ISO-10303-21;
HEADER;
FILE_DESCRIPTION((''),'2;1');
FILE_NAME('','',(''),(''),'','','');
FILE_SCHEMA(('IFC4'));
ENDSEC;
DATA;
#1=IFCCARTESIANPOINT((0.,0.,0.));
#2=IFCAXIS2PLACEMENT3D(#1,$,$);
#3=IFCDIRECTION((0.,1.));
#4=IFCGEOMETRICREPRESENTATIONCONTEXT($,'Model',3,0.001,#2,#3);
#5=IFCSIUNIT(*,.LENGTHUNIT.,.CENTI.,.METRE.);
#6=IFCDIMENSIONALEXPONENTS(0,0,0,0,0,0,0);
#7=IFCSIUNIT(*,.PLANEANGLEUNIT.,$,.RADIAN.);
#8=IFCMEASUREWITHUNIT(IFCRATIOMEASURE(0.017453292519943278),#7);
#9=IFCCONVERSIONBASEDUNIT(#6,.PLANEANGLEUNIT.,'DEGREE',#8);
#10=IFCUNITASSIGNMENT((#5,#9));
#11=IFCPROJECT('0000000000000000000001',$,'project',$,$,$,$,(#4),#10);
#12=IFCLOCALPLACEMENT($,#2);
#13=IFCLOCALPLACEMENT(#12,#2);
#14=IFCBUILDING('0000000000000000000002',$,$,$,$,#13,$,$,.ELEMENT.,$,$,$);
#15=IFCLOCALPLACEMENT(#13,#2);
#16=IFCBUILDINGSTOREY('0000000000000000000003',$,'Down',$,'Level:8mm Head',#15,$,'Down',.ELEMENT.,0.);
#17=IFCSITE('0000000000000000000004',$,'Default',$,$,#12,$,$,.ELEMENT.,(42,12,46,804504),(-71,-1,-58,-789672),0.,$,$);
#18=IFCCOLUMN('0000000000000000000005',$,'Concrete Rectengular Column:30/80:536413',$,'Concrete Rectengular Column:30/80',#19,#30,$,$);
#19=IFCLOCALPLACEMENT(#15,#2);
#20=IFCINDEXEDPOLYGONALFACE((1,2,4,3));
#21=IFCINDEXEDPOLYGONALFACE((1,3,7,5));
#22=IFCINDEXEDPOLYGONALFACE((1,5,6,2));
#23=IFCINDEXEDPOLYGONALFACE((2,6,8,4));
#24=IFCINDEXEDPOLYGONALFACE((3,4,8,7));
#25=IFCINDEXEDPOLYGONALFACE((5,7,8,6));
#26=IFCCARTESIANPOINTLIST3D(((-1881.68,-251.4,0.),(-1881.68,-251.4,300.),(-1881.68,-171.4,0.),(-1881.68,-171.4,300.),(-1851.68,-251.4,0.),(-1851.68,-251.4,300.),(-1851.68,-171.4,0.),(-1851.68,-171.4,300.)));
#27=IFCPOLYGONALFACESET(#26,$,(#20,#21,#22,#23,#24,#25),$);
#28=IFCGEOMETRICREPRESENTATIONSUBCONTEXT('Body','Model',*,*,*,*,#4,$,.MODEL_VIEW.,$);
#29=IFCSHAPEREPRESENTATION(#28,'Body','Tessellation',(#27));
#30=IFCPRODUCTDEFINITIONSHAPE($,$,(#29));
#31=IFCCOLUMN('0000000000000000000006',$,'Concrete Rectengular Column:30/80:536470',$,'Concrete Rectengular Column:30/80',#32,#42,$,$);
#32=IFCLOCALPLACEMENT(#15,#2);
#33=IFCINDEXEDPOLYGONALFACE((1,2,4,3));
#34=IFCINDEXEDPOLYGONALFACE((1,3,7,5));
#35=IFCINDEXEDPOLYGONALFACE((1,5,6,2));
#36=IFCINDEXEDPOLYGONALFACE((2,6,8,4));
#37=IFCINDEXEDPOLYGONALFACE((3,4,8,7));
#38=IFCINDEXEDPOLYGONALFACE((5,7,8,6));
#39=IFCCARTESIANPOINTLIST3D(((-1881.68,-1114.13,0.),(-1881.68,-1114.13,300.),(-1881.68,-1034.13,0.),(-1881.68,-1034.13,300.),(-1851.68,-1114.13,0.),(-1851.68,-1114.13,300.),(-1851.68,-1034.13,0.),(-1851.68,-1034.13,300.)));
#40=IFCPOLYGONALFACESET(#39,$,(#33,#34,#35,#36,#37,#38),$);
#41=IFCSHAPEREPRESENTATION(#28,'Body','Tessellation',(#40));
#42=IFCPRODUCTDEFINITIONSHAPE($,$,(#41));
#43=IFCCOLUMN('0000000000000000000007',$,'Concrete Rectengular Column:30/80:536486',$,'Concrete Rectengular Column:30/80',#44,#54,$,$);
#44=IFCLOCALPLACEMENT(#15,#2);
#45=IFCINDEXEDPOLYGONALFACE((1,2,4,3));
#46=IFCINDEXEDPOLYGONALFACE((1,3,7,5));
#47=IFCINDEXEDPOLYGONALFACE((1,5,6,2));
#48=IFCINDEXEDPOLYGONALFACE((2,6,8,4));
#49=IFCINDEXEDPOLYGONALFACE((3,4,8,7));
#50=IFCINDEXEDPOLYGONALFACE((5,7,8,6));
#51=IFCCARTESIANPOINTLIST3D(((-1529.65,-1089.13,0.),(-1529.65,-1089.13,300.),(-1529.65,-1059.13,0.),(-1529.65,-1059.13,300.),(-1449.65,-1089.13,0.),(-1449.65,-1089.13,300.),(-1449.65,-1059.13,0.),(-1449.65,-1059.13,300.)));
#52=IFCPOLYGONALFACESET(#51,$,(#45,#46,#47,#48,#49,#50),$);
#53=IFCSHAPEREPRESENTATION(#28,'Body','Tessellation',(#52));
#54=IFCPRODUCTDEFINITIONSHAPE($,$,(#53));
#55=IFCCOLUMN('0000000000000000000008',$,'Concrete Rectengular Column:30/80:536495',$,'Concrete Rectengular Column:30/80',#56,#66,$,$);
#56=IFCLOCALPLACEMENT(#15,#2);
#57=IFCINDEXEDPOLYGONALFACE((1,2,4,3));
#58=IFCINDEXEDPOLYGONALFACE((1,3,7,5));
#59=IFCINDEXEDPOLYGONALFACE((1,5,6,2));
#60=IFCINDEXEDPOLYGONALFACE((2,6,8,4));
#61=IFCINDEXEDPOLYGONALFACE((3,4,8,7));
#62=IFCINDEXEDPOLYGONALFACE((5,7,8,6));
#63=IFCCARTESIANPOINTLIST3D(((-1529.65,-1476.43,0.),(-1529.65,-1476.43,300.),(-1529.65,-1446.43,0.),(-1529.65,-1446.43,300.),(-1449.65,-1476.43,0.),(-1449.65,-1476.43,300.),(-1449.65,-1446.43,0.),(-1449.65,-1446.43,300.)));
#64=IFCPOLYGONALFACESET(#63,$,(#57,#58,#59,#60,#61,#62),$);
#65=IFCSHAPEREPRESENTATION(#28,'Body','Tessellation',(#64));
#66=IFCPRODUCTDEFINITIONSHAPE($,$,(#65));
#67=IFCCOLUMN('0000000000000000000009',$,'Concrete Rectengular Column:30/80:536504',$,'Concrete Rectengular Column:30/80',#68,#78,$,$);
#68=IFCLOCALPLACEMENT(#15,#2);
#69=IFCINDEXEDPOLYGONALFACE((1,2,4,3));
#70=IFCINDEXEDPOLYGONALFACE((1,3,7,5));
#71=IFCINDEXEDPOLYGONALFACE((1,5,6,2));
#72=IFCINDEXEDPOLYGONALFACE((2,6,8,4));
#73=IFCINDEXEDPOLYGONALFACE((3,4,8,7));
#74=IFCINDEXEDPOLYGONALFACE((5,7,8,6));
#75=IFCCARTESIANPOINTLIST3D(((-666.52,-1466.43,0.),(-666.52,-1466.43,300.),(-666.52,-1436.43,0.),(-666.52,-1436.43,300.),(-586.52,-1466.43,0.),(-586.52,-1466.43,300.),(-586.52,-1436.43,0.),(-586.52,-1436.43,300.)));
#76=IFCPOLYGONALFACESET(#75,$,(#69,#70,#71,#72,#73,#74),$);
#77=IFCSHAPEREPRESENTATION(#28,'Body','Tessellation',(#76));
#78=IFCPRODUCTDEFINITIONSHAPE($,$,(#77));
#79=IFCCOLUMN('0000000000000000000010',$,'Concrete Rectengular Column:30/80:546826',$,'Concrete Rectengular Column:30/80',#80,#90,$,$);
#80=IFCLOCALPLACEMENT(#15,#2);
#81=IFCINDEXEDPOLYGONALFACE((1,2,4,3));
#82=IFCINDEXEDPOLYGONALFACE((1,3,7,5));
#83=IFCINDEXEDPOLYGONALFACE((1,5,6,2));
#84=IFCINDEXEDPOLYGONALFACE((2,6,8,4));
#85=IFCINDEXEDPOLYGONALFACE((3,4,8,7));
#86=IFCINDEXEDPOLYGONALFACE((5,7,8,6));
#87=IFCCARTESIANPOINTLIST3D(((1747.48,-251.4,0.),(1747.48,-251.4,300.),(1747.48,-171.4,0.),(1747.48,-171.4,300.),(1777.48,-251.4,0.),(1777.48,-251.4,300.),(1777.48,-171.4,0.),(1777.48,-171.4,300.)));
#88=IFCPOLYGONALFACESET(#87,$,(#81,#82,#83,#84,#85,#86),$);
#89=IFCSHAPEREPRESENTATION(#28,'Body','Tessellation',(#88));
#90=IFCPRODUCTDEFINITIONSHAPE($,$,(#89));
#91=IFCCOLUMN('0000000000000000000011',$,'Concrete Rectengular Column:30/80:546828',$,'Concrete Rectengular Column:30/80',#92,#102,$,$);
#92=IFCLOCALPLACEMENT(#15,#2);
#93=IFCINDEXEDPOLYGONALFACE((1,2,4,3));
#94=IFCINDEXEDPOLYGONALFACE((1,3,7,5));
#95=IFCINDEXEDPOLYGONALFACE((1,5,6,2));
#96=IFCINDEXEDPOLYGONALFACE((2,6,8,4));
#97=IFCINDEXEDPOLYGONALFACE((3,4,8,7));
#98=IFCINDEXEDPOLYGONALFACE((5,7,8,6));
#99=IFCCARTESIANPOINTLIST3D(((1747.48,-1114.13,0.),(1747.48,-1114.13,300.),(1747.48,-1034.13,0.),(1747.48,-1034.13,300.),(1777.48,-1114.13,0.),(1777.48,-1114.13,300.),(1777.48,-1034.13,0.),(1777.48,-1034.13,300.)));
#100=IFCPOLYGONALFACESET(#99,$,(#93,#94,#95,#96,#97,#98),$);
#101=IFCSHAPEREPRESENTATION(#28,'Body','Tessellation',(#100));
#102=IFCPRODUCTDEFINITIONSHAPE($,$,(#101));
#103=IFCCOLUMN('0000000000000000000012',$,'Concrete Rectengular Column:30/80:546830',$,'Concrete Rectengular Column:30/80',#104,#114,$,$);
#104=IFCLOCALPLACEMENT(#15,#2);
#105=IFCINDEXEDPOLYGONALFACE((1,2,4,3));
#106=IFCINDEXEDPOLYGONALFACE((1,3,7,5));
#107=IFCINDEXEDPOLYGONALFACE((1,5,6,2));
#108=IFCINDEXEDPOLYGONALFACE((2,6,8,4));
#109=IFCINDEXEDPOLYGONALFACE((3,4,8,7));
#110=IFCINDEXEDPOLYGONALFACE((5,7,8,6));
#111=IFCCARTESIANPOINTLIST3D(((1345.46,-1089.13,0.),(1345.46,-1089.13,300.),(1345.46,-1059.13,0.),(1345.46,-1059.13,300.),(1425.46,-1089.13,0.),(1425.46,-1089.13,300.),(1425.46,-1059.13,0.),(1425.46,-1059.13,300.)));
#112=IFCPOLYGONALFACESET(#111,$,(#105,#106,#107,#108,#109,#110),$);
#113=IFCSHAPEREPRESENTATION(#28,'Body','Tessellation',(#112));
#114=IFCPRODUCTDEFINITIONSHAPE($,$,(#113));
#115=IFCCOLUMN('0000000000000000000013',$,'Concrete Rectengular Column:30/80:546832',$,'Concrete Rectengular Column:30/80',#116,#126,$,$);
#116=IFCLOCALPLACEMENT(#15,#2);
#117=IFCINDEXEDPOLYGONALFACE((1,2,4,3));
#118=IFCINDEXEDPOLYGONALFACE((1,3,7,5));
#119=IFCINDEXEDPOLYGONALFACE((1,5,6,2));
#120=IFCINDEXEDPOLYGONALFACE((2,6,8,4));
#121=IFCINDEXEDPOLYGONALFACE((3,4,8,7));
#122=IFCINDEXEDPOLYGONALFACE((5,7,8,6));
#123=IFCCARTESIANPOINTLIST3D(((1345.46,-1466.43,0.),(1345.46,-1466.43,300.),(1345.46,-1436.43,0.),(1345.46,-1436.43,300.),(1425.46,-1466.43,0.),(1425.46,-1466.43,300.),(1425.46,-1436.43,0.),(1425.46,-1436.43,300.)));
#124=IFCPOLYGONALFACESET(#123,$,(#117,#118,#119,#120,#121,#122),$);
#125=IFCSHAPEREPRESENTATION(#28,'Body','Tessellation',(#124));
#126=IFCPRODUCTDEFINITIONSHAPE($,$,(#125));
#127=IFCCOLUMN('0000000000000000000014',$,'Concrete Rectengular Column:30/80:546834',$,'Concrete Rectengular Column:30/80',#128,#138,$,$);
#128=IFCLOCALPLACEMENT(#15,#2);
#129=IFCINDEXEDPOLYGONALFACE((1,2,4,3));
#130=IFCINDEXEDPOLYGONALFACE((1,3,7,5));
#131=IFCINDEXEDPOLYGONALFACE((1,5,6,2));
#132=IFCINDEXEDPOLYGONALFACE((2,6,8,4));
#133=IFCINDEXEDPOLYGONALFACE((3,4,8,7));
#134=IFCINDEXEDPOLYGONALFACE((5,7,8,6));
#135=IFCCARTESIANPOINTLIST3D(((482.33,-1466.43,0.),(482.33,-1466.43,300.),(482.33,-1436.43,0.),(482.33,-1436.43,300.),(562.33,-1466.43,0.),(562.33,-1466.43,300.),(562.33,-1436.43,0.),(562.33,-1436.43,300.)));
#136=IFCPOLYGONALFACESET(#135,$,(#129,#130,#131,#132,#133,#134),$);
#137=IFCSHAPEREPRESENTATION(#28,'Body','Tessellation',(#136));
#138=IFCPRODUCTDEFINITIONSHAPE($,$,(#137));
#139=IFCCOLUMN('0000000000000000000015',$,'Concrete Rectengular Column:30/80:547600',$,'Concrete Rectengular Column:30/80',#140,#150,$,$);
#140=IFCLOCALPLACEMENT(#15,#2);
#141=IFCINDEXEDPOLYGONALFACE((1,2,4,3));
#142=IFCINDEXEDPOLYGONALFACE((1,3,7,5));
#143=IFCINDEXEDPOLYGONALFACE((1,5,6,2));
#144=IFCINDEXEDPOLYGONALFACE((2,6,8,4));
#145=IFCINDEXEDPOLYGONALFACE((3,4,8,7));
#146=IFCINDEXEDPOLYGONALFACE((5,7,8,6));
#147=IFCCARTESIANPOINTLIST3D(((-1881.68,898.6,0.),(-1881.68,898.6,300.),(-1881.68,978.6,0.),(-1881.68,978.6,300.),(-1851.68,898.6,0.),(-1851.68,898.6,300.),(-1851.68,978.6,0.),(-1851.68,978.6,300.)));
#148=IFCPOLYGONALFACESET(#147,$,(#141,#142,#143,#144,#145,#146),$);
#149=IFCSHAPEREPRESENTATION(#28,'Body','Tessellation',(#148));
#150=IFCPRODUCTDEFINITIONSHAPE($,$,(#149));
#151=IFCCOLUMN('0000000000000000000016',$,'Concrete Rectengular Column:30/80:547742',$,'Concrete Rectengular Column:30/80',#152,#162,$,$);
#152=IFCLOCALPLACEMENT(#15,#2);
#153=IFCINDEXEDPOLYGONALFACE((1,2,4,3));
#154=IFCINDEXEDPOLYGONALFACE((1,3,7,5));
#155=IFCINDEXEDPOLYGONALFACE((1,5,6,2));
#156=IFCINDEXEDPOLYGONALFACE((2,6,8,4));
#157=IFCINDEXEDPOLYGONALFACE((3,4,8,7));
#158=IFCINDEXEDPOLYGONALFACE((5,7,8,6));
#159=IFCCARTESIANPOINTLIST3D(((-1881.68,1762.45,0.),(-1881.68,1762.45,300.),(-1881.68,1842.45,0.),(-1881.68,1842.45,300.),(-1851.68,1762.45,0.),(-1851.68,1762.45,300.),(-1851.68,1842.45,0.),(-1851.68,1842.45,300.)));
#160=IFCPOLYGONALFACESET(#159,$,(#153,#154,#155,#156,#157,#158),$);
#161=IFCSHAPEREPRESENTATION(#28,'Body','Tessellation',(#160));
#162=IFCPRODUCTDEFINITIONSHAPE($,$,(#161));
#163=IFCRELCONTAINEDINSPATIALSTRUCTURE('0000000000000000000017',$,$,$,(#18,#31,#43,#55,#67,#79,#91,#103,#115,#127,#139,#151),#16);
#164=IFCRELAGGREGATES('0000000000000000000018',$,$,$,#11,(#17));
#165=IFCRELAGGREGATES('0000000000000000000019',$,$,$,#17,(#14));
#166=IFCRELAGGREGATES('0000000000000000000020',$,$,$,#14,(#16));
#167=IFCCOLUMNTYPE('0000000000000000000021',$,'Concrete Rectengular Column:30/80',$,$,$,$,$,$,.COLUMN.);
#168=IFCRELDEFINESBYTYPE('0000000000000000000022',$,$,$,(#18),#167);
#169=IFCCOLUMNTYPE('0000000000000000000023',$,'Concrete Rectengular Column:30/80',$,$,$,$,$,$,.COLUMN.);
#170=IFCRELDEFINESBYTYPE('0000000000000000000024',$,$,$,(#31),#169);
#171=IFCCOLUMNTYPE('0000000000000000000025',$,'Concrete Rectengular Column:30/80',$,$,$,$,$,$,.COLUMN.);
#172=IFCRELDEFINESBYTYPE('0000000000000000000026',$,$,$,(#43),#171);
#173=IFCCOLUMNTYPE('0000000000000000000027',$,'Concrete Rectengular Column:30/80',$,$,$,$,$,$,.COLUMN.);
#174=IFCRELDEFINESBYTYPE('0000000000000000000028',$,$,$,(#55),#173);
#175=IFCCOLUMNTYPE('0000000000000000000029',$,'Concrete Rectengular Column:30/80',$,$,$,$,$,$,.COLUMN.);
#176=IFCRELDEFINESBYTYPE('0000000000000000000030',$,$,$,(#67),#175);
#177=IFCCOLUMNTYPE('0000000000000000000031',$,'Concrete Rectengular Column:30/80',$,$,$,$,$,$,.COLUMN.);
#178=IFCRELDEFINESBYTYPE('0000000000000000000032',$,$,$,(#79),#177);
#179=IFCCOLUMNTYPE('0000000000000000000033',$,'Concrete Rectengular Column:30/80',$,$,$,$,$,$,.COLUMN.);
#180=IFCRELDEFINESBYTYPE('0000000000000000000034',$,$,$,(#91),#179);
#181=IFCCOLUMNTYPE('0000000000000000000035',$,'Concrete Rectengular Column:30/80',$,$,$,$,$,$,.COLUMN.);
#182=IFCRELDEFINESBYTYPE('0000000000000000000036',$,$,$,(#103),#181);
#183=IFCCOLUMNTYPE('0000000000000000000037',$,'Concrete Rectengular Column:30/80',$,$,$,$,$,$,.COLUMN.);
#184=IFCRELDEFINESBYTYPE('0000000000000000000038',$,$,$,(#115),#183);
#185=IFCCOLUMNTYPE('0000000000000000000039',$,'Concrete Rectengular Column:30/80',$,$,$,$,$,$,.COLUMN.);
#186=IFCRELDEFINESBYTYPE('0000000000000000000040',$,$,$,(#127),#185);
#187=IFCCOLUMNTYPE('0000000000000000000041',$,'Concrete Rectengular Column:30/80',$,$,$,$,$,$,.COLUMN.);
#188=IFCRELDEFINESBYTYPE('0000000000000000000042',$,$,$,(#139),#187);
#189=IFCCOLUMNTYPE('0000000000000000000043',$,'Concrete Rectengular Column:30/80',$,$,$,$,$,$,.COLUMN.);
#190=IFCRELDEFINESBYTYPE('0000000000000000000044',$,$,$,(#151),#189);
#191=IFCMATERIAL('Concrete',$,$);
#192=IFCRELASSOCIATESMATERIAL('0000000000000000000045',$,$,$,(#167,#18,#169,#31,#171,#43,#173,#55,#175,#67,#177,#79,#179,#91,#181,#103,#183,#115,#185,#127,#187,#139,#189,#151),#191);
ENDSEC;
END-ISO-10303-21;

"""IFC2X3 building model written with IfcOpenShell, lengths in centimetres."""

from ifc_helpers import new_model, entity, si_unit, converted_unit, direction, frame, frame_2d, origin, origin_2d_with_axis, place, context, subcontext, project, spatial, rectangle, extrude, source, transform, mapped, material, type_object, type_shapes, element, save


model = new_model("IFC2X3")

# Units and contexts
model_context = context("Model", 3, precision=0.001, world=origin(), true_north=direction((0.0, 1.0)))
body_context = subcontext(model_context, "Body", "Model", "MODEL_VIEW")
ifc_project = project(units=[si_unit("LENGTHUNIT", "METRE", prefix="CENTI"), converted_unit("PLANEANGLEUNIT", "DEGREE", entity("IfcRatioMeasure", 0.017453292519943278), si_unit("PLANEANGLEUNIT", "RADIAN"), dimensions=[0, 0, 0, 0, 0, 0, 0])], contexts=[model_context])

# Site, building, storey
site_placement = place(None, origin())
site = spatial("IfcSite", under=ifc_project, at=site_placement, Name="Default", CompositionType="ELEMENT", RefLatitude=(42, 12, 46, 804504), RefLongitude=(-71, -1, -58, -789672), RefElevation=0.0)
building_placement = place(site_placement, origin())
building = spatial("IfcBuilding", under=site, at=building_placement, CompositionType="ELEMENT")
storey_placement = place(building_placement, origin())
storey = spatial("IfcBuildingStorey", under=building, at=storey_placement, Name="Down", ObjectType="Level:8mm Head", LongName="Down", CompositionType="ELEMENT", Elevation=0.0)

# Columns
ifc_material = material(Name="Concrete")
column_type_1 = type_object("IfcColumnType", Name="Concrete Rectengular Column:30/80", PredefinedType="COLUMN", material=ifc_material)
shared_shape_1 = source(origin(), body_context, "Body", "SweptSolid", [
    extrude(rectangle(XDim=80.0, YDim=30.0, at=frame_2d((0.0, 0.0), x_axis=(1.0, 0.0))), frame((-1866.68, -211.4, 0.0), z_axis=(0.0, 0.0, 1.0), x_axis=(0.0, -1.0, 0.0)), (0.0, 0.0, 1.0), 300.0),
])
type_shapes(column_type_1, [shared_shape_1])
column_1_placement = place(storey_placement, origin())
element("IfcColumn", 1, at=column_1_placement, inside=storey, type_object=column_type_1, material=ifc_material, Name="Concrete Rectengular Column:30/80:536413", ObjectType="Concrete Rectengular Column:30/80", context=body_context, shape_type="MappedRepresentation", body=[
    mapped(shared_shape_1, transform((0.0, 0.0, 0.0), scale=1.0)),
])
column_type_2 = type_object("IfcColumnType", Name="Concrete Rectengular Column:30/80", PredefinedType="COLUMN", material=ifc_material)
shared_shape_2 = source(origin(), body_context, "Body", "SweptSolid", [
    extrude(rectangle(XDim=80.0, YDim=30.0, at=frame_2d((0.0, 0.0), x_axis=(1.0, 0.0))), frame((-1866.68, -1074.13, 0.0), z_axis=(0.0, 0.0, 1.0), x_axis=(0.0, -1.0, 0.0)), (0.0, 0.0, 1.0), 300.0),
])
type_shapes(column_type_2, [shared_shape_2])
column_2_placement = place(storey_placement, origin())
element("IfcColumn", 2, at=column_2_placement, inside=storey, type_object=column_type_2, material=ifc_material, Name="Concrete Rectengular Column:30/80:536470", ObjectType="Concrete Rectengular Column:30/80", context=body_context, shape_type="MappedRepresentation", body=[
    mapped(shared_shape_2, transform((0.0, 0.0, 0.0), scale=1.0)),
])
column_type_3 = type_object("IfcColumnType", Name="Concrete Rectengular Column:30/80", PredefinedType="COLUMN", material=ifc_material)
shared_shape_3 = source(origin(), body_context, "Body", "SweptSolid", [
    extrude(rectangle(XDim=30.0, YDim=80.0, at=origin_2d_with_axis()), frame((-1489.65, -1074.13, 0.0), z_axis=(0.0, 0.0, 1.0), x_axis=(0.0, -1.0, 0.0)), (0.0, 0.0, 1.0), 300.0),
])
type_shapes(column_type_3, [shared_shape_3])
column_3_placement = place(storey_placement, origin())
element("IfcColumn", 3, at=column_3_placement, inside=storey, type_object=column_type_3, material=ifc_material, Name="Concrete Rectengular Column:30/80:536486", ObjectType="Concrete Rectengular Column:30/80", context=body_context, shape_type="MappedRepresentation", body=[
    mapped(shared_shape_3, transform((0.0, 0.0, 0.0), scale=1.0)),
])
column_type_4 = type_object("IfcColumnType", Name="Concrete Rectengular Column:30/80", PredefinedType="COLUMN", material=ifc_material)
shared_shape_4 = source(origin(), body_context, "Body", "SweptSolid", [
    extrude(rectangle(XDim=30.0, YDim=80.0, at=origin_2d_with_axis()), frame((-1489.65, -1461.43, 0.0), z_axis=(0.0, 0.0, 1.0), x_axis=(0.0, -1.0, 0.0)), (0.0, 0.0, 1.0), 300.0),
])
type_shapes(column_type_4, [shared_shape_4])
column_4_placement = place(storey_placement, origin())
element("IfcColumn", 4, at=column_4_placement, inside=storey, type_object=column_type_4, material=ifc_material, Name="Concrete Rectengular Column:30/80:536495", ObjectType="Concrete Rectengular Column:30/80", context=body_context, shape_type="MappedRepresentation", body=[
    mapped(shared_shape_4, transform((0.0, 0.0, 0.0), scale=1.0)),
])
column_type_5 = type_object("IfcColumnType", Name="Concrete Rectengular Column:30/80", PredefinedType="COLUMN", material=ifc_material)
shared_shape_5 = source(origin(), body_context, "Body", "SweptSolid", [
    extrude(rectangle(XDim=30.0, YDim=80.0, at=origin_2d_with_axis()), frame((-626.52, -1451.43, 0.0), z_axis=(0.0, 0.0, 1.0), x_axis=(0.0, -1.0, 0.0)), (0.0, 0.0, 1.0), 300.0),
])
type_shapes(column_type_5, [shared_shape_5])
column_5_placement = place(storey_placement, origin())
element("IfcColumn", 5, at=column_5_placement, inside=storey, type_object=column_type_5, material=ifc_material, Name="Concrete Rectengular Column:30/80:536504", ObjectType="Concrete Rectengular Column:30/80", context=body_context, shape_type="MappedRepresentation", body=[
    mapped(shared_shape_5, transform((0.0, 0.0, 0.0), scale=1.0)),
])
column_type_6 = type_object("IfcColumnType", Name="Concrete Rectengular Column:30/80", PredefinedType="COLUMN", material=ifc_material)
shared_shape_6 = source(origin(), body_context, "Body", "SweptSolid", [
    extrude(rectangle(XDim=80.0, YDim=30.0, at=frame_2d((0.0, 0.0), x_axis=(1.0, 0.0))), frame((1762.48, -211.4, 0.0), z_axis=(0.0, 0.0, 1.0), x_axis=(0.0, -1.0, 0.0)), (0.0, 0.0, 1.0), 300.0),
])
type_shapes(column_type_6, [shared_shape_6])
column_6_placement = place(storey_placement, origin())
element("IfcColumn", 6, at=column_6_placement, inside=storey, type_object=column_type_6, material=ifc_material, Name="Concrete Rectengular Column:30/80:546826", ObjectType="Concrete Rectengular Column:30/80", context=body_context, shape_type="MappedRepresentation", body=[
    mapped(shared_shape_6, transform((0.0, 0.0, 0.0), scale=1.0)),
])
column_type_7 = type_object("IfcColumnType", Name="Concrete Rectengular Column:30/80", PredefinedType="COLUMN", material=ifc_material)
shared_shape_7 = source(origin(), body_context, "Body", "SweptSolid", [
    extrude(rectangle(XDim=80.0, YDim=30.0, at=origin_2d_with_axis()), frame((1762.48, -1074.13, 0.0), z_axis=(0.0, 0.0, 1.0), x_axis=(0.0, -1.0, 0.0)), (0.0, 0.0, 1.0), 300.0),
])
type_shapes(column_type_7, [shared_shape_7])
column_7_placement = place(storey_placement, origin())
element("IfcColumn", 7, at=column_7_placement, inside=storey, type_object=column_type_7, material=ifc_material, Name="Concrete Rectengular Column:30/80:546828", ObjectType="Concrete Rectengular Column:30/80", context=body_context, shape_type="MappedRepresentation", body=[
    mapped(shared_shape_7, transform((0.0, 0.0, 0.0), scale=1.0)),
])
column_type_8 = type_object("IfcColumnType", Name="Concrete Rectengular Column:30/80", PredefinedType="COLUMN", material=ifc_material)
shared_shape_8 = source(origin(), body_context, "Body", "SweptSolid", [
    extrude(rectangle(XDim=30.0, YDim=80.0, at=origin_2d_with_axis()), frame((1385.46, -1074.13, 0.0), z_axis=(0.0, 0.0, 1.0), x_axis=(0.0, -1.0, 0.0)), (0.0, 0.0, 1.0), 300.0),
])
type_shapes(column_type_8, [shared_shape_8])
column_8_placement = place(storey_placement, origin())
element("IfcColumn", 8, at=column_8_placement, inside=storey, type_object=column_type_8, material=ifc_material, Name="Concrete Rectengular Column:30/80:546830", ObjectType="Concrete Rectengular Column:30/80", context=body_context, shape_type="MappedRepresentation", body=[
    mapped(shared_shape_8, transform((0.0, 0.0, 0.0), scale=1.0)),
])
column_type_9 = type_object("IfcColumnType", Name="Concrete Rectengular Column:30/80", PredefinedType="COLUMN", material=ifc_material)
shared_shape_9 = source(origin(), body_context, "Body", "SweptSolid", [
    extrude(rectangle(XDim=30.0, YDim=80.0, at=frame_2d((0.0, 0.0), x_axis=(1.0, 0.0))), frame((1385.46, -1451.43, 0.0), z_axis=(0.0, 0.0, 1.0), x_axis=(0.0, -1.0, 0.0)), (0.0, 0.0, 1.0), 300.0),
])
type_shapes(column_type_9, [shared_shape_9])
column_9_placement = place(storey_placement, origin())
element("IfcColumn", 9, at=column_9_placement, inside=storey, type_object=column_type_9, material=ifc_material, Name="Concrete Rectengular Column:30/80:546832", ObjectType="Concrete Rectengular Column:30/80", context=body_context, shape_type="MappedRepresentation", body=[
    mapped(shared_shape_9, transform((0.0, 0.0, 0.0), scale=1.0)),
])
column_type_10 = type_object("IfcColumnType", Name="Concrete Rectengular Column:30/80", PredefinedType="COLUMN", material=ifc_material)
shared_shape_10 = source(origin(), body_context, "Body", "SweptSolid", [
    extrude(rectangle(XDim=30.0, YDim=80.0, at=frame_2d((0.0, 0.0), x_axis=(1.0, 0.0))), frame((522.33, -1451.43, 0.0), z_axis=(0.0, 0.0, 1.0), x_axis=(0.0, -1.0, 0.0)), (0.0, 0.0, 1.0), 300.0),
])
type_shapes(column_type_10, [shared_shape_10])
column_10_placement = place(storey_placement, origin())
element("IfcColumn", 10, at=column_10_placement, inside=storey, type_object=column_type_10, material=ifc_material, Name="Concrete Rectengular Column:30/80:546834", ObjectType="Concrete Rectengular Column:30/80", context=body_context, shape_type="MappedRepresentation", body=[
    mapped(shared_shape_10, transform((0.0, 0.0, 0.0), scale=1.0)),
])
column_type_11 = type_object("IfcColumnType", Name="Concrete Rectengular Column:30/80", PredefinedType="COLUMN", material=ifc_material)
shared_shape_11 = source(origin(), body_context, "Body", "SweptSolid", [
    extrude(rectangle(XDim=80.0, YDim=30.0, at=origin_2d_with_axis()), frame((-1866.68, 938.6, 0.0), z_axis=(0.0, 0.0, 1.0), x_axis=(0.0, -1.0, 0.0)), (0.0, 0.0, 1.0), 300.0),
])
type_shapes(column_type_11, [shared_shape_11])
column_11_placement = place(storey_placement, origin())
element("IfcColumn", 11, at=column_11_placement, inside=storey, type_object=column_type_11, material=ifc_material, Name="Concrete Rectengular Column:30/80:547600", ObjectType="Concrete Rectengular Column:30/80", context=body_context, shape_type="MappedRepresentation", body=[
    mapped(shared_shape_11, transform((0.0, 0.0, 0.0), scale=1.0)),
])
column_type_12 = type_object("IfcColumnType", Name="Concrete Rectengular Column:30/80", PredefinedType="COLUMN", material=ifc_material)
shared_shape_12 = source(origin(), body_context, "Body", "SweptSolid", [
    extrude(rectangle(XDim=80.0, YDim=30.0, at=frame_2d((0.0, 0.0), x_axis=(1.0, 0.0))), frame((-1866.68, 1802.45, 0.0), z_axis=(0.0, 0.0, 1.0), x_axis=(0.0, -1.0, 0.0)), (0.0, 0.0, 1.0), 300.0),
])
type_shapes(column_type_12, [shared_shape_12])
column_12_placement = place(storey_placement, origin())
element("IfcColumn", 12, at=column_12_placement, inside=storey, type_object=column_type_12, material=ifc_material, Name="Concrete Rectengular Column:30/80:547742", ObjectType="Concrete Rectengular Column:30/80", context=body_context, shape_type="MappedRepresentation", body=[
    mapped(shared_shape_12, transform((0.0, 0.0, 0.0), scale=1.0)),
])

save(model, "model.ifc")
